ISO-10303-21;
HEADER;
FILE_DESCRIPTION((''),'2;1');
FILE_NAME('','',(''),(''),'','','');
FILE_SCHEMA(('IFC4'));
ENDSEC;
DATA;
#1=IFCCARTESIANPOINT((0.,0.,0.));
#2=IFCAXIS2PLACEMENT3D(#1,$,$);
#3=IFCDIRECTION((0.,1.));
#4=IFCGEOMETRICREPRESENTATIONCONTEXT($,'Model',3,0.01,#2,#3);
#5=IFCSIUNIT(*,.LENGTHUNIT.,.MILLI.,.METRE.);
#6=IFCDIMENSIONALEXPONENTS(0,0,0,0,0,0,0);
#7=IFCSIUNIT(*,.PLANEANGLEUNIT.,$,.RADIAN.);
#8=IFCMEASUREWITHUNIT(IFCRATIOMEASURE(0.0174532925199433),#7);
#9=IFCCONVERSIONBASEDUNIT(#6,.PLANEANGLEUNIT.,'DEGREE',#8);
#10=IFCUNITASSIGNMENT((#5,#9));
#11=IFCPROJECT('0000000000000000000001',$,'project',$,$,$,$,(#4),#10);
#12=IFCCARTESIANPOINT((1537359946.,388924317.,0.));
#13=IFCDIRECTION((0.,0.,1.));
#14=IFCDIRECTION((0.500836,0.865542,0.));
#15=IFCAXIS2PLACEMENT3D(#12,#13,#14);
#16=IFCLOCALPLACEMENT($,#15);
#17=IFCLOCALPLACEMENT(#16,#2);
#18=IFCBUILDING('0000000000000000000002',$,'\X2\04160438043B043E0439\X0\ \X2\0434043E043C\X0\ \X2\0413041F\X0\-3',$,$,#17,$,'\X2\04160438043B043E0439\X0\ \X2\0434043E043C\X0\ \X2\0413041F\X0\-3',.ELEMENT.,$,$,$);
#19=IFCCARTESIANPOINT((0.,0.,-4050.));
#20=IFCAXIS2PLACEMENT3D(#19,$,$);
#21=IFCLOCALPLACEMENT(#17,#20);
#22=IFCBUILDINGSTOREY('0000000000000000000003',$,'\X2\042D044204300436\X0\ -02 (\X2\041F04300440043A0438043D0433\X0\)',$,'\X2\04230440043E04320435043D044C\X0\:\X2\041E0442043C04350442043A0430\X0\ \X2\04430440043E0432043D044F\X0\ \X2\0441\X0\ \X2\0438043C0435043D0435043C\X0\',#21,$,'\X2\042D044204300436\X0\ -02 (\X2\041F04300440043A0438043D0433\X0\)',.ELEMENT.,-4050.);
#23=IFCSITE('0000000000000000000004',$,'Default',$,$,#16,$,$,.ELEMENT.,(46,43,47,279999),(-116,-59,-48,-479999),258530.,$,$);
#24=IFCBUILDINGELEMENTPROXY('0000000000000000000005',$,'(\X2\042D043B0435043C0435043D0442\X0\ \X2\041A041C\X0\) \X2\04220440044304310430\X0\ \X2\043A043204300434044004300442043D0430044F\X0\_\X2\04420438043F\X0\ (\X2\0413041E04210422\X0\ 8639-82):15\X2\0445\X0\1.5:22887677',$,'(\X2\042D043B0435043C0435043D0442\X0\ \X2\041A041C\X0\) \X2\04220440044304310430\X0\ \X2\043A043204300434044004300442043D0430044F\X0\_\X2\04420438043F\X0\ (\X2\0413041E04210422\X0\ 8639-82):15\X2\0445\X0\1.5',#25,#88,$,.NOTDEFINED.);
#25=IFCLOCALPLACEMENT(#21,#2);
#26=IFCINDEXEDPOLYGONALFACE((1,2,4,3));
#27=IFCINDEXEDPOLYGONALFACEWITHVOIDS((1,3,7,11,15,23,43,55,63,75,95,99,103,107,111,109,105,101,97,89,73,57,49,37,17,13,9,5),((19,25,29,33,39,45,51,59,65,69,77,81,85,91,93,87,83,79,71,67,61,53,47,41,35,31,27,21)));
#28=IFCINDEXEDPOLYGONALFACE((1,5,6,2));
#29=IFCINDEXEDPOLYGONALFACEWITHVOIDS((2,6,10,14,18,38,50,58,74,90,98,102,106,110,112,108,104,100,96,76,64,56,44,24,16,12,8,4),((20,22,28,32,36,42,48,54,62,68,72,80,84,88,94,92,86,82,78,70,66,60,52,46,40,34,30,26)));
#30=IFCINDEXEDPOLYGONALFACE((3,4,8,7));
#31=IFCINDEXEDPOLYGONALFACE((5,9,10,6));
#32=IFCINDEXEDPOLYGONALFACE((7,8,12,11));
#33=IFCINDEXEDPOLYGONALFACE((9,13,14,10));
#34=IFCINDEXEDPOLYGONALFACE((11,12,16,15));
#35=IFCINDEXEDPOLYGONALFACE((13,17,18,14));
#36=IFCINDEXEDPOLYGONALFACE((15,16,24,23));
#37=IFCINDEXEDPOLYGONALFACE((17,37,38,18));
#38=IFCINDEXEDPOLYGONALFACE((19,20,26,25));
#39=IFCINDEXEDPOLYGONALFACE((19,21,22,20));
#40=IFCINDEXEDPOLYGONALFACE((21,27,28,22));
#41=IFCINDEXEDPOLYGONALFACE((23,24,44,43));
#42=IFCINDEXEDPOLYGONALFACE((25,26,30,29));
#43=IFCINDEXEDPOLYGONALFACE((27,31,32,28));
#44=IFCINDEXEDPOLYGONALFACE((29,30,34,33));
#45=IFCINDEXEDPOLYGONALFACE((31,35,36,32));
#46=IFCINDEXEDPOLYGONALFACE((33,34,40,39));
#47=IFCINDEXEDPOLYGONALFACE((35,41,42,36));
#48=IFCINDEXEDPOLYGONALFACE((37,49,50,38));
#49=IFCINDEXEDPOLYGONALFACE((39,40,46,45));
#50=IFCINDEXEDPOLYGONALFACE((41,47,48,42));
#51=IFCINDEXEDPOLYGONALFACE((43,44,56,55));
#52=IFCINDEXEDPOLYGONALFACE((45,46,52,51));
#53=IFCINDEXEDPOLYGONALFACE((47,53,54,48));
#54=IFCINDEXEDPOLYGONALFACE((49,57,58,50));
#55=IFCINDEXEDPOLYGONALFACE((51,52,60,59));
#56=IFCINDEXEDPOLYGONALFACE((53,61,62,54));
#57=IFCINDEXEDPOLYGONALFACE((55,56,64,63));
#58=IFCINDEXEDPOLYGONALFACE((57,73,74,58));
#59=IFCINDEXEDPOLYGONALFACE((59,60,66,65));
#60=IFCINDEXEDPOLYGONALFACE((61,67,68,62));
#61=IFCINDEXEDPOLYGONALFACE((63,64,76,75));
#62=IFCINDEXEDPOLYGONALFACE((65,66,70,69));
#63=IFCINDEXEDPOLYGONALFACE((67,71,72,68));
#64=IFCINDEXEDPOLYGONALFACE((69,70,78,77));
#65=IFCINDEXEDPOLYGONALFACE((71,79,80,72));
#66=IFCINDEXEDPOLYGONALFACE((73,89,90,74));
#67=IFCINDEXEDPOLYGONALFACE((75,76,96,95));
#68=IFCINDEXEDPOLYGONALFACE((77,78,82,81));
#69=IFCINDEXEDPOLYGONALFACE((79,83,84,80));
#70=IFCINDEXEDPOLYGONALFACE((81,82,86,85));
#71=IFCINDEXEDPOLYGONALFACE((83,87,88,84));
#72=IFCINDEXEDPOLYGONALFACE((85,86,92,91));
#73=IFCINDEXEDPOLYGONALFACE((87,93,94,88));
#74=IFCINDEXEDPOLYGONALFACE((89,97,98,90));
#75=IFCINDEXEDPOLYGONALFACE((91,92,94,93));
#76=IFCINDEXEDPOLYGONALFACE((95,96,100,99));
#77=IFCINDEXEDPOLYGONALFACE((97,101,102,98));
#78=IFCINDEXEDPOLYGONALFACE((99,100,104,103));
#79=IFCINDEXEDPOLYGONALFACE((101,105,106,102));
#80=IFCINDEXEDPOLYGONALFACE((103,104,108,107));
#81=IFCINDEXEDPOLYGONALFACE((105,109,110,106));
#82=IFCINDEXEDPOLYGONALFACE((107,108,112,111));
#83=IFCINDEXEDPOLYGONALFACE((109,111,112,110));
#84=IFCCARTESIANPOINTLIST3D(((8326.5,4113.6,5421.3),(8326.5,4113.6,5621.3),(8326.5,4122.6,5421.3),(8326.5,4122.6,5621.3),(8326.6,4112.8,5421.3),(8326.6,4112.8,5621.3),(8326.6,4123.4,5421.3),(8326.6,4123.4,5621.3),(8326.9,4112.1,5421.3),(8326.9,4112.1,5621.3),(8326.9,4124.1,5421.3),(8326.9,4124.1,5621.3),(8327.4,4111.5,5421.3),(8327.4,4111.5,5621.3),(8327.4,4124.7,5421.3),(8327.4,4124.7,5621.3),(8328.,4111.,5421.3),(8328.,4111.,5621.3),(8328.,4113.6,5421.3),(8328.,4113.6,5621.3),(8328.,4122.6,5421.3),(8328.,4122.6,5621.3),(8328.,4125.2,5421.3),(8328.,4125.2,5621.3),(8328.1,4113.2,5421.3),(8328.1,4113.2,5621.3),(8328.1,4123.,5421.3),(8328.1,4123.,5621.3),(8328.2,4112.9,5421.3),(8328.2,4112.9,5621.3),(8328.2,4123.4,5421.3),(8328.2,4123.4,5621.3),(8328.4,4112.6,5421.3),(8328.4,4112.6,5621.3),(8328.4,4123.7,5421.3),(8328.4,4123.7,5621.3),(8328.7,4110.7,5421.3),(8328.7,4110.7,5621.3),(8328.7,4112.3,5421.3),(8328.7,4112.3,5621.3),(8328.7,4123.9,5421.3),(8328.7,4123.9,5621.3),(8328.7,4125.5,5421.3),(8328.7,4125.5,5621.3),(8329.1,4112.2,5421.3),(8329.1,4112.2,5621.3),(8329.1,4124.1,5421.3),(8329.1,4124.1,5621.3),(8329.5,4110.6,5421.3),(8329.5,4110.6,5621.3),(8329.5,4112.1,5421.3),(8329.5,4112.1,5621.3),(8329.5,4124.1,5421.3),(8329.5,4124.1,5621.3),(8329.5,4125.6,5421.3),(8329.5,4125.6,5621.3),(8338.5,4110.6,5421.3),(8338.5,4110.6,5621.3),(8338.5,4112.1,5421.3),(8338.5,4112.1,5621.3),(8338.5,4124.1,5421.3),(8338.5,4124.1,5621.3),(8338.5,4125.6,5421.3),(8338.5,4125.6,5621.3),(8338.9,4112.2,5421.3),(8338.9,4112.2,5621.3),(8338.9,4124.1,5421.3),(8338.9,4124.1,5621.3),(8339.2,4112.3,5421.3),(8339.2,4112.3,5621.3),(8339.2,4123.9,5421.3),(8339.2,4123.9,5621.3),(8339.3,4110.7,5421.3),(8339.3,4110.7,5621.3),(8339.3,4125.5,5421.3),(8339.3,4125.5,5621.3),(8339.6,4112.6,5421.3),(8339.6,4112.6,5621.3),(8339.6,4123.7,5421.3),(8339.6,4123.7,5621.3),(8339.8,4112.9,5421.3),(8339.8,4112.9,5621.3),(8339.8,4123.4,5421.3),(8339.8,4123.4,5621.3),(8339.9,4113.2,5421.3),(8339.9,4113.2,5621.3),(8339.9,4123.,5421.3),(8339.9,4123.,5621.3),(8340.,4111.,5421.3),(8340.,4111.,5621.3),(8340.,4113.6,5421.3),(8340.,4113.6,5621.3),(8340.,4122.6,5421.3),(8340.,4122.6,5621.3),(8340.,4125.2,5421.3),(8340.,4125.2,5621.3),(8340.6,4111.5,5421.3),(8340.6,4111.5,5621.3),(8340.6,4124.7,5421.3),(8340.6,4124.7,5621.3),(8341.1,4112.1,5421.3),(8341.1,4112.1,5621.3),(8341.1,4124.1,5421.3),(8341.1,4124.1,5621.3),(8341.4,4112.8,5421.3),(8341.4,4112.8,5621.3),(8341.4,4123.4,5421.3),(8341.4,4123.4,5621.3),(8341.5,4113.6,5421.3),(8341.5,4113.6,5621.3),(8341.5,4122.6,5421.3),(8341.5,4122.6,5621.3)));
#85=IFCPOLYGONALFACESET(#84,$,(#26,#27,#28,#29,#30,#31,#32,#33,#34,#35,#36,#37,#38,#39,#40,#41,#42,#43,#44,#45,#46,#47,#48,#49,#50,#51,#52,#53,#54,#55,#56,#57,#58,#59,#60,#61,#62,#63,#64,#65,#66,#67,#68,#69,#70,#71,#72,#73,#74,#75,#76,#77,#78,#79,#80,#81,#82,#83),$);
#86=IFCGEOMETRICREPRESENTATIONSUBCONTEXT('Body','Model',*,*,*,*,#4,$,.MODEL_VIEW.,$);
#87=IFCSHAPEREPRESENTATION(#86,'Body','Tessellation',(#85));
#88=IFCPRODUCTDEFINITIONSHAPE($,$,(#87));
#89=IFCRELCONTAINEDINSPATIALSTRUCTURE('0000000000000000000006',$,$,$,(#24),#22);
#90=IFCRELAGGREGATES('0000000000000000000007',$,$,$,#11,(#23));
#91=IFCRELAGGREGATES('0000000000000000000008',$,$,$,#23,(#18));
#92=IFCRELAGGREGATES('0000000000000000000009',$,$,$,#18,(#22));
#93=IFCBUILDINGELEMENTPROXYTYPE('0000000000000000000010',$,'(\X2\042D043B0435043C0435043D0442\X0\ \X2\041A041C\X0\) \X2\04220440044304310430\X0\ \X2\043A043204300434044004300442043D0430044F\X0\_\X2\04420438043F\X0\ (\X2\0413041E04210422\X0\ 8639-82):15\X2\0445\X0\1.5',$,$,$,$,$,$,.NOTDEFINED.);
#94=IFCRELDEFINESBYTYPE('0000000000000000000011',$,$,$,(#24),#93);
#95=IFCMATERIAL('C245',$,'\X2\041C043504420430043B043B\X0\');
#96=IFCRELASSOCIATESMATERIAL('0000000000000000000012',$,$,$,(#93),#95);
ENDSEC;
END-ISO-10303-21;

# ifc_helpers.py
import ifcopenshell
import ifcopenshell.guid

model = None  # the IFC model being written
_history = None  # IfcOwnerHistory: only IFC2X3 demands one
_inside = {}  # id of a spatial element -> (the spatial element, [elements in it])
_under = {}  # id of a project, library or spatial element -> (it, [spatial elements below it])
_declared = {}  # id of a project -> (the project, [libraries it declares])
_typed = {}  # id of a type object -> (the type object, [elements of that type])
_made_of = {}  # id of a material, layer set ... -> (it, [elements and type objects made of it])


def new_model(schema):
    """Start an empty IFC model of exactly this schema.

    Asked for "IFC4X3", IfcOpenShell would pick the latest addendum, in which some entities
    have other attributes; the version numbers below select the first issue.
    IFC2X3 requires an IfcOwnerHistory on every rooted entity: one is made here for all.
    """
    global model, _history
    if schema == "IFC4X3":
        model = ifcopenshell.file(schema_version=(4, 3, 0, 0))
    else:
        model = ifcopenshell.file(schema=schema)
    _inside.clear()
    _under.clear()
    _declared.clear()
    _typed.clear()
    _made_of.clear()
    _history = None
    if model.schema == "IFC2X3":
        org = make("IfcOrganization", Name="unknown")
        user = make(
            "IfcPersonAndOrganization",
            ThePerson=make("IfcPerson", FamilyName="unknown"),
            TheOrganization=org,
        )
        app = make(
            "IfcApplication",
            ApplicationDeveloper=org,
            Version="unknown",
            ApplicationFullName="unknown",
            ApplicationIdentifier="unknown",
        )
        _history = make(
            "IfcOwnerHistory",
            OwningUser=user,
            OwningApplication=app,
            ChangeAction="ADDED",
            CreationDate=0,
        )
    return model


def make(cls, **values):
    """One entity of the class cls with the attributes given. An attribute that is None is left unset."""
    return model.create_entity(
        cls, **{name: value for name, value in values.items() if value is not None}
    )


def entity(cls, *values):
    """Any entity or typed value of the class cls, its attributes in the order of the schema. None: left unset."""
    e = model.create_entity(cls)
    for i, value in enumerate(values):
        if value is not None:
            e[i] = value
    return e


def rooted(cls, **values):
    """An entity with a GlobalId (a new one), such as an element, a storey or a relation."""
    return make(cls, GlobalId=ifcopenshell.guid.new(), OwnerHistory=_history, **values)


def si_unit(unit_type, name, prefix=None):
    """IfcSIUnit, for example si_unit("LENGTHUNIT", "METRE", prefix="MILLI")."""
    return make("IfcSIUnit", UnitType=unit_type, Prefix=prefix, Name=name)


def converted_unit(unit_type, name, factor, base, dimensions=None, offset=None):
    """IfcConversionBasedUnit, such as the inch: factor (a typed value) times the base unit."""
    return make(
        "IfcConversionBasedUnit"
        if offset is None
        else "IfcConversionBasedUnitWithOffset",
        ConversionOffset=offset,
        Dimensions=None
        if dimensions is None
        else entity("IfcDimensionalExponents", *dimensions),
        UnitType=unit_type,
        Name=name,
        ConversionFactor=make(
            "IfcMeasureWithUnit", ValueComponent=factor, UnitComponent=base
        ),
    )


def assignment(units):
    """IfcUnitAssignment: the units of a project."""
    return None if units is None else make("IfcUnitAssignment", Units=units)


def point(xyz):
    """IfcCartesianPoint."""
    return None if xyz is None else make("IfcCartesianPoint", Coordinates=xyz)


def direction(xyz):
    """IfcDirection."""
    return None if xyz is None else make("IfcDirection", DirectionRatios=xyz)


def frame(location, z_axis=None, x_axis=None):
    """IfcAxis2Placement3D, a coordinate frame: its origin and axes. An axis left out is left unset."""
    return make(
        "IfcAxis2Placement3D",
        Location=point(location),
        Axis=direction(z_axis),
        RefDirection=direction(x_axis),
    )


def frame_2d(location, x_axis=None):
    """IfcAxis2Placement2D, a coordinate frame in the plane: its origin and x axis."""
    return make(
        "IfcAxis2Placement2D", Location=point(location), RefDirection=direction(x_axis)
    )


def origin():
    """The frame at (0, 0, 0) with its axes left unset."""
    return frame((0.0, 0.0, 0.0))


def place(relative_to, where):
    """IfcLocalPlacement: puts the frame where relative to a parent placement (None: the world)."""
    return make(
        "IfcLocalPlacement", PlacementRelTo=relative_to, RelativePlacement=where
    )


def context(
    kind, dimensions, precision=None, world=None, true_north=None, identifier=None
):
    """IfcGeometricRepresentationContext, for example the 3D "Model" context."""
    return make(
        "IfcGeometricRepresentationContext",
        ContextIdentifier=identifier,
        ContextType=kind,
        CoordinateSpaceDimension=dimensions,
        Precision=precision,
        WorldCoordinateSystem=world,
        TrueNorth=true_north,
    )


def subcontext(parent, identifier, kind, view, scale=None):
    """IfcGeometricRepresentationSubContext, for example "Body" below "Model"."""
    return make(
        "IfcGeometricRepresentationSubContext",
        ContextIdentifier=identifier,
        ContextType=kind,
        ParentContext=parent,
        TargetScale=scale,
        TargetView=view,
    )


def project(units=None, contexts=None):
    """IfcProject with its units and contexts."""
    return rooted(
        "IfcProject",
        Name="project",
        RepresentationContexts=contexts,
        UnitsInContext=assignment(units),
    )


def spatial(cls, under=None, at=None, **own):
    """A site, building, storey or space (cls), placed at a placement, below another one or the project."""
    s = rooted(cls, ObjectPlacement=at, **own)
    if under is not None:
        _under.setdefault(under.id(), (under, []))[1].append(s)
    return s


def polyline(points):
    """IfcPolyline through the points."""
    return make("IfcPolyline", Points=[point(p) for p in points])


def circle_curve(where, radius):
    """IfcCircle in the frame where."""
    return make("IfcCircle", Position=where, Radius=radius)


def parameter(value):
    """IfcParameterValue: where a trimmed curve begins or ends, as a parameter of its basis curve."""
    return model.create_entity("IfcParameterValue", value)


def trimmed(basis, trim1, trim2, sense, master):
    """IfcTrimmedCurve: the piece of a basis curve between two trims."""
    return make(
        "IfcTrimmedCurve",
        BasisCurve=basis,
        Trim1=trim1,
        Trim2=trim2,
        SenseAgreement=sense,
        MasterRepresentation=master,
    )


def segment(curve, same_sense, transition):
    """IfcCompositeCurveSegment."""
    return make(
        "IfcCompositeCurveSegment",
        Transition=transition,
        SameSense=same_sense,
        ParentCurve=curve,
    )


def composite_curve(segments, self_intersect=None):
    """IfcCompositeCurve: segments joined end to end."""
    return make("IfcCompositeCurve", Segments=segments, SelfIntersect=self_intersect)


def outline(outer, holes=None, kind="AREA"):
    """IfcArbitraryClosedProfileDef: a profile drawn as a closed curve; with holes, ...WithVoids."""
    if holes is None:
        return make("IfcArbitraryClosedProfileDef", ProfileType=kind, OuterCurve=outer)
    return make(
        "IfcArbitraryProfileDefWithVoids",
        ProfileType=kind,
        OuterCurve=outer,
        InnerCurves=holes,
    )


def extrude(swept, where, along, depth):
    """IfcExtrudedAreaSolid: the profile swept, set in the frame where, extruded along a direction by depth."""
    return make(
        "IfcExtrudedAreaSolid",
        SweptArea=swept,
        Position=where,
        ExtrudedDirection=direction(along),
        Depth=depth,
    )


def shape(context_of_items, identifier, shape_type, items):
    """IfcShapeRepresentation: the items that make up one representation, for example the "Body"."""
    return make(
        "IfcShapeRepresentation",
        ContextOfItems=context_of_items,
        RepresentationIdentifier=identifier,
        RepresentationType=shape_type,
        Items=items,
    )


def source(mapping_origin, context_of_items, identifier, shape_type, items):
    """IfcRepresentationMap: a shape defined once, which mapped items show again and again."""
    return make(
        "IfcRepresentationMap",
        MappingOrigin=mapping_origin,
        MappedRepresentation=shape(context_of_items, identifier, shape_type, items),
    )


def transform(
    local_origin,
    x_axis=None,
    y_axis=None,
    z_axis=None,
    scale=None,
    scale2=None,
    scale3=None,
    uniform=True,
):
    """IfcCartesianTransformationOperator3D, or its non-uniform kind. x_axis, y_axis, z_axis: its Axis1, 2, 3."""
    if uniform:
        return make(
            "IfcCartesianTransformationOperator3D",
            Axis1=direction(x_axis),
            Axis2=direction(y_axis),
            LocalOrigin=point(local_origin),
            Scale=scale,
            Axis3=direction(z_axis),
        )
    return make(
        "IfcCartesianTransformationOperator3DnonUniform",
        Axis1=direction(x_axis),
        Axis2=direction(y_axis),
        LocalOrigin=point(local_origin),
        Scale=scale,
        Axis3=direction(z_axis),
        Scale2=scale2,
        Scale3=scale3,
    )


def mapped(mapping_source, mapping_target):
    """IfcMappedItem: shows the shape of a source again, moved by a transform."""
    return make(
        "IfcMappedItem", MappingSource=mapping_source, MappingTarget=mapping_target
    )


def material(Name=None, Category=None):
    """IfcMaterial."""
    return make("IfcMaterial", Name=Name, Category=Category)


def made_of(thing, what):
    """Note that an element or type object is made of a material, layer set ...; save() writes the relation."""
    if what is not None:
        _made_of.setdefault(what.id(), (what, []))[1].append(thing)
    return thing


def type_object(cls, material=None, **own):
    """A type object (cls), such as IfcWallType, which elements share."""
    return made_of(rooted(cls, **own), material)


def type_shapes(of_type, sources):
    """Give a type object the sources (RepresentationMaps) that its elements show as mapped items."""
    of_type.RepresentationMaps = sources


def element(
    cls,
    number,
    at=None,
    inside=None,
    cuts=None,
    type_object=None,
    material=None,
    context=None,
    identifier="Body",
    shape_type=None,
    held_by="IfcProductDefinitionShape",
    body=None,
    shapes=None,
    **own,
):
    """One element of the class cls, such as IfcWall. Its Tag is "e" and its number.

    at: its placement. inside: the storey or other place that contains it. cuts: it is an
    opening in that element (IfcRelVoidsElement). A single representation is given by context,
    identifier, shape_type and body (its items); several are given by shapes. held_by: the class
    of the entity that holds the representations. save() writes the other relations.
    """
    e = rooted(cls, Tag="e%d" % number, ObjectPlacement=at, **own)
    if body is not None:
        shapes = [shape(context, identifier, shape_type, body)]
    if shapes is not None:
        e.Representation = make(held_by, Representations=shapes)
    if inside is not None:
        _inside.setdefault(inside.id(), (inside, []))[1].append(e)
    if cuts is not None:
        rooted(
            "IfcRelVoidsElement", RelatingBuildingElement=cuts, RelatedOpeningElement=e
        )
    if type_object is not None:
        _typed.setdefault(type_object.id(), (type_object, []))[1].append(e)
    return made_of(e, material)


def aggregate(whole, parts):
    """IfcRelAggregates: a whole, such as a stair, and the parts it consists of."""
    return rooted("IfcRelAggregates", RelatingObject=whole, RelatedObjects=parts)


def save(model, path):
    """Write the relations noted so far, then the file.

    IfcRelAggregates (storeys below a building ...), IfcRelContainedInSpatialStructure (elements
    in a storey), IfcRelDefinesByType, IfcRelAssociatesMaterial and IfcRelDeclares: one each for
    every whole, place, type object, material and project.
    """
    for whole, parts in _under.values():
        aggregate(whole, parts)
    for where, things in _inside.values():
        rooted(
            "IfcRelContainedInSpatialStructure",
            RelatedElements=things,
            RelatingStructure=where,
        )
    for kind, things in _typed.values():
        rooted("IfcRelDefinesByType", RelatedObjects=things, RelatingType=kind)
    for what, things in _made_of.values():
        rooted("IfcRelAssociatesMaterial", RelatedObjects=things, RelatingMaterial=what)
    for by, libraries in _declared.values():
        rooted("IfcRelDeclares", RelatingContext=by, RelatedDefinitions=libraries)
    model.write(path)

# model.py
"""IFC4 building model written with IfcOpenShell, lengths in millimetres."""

from ifc_helpers import new_model, entity, si_unit, converted_unit, direction, frame, frame_2d, origin, place, context, subcontext, project, spatial, polyline, circle_curve, parameter, trimmed, segment, composite_curve, outline, extrude, source, transform, mapped, material, type_object, type_shapes, element, save


model = new_model("IFC4")

# Units and contexts
model_context = context("Model", 3, precision=0.01, world=origin(), true_north=direction((0.0, 1.0)))
body_context = subcontext(model_context, "Body", "Model", "MODEL_VIEW")
ifc_project = project(units=[si_unit("LENGTHUNIT", "METRE", prefix="MILLI"), converted_unit("PLANEANGLEUNIT", "DEGREE", entity("IfcRatioMeasure", 0.0174532925199433), si_unit("PLANEANGLEUNIT", "RADIAN"), dimensions=[0, 0, 0, 0, 0, 0, 0])], contexts=[model_context])

# Site, building, storey
site_placement = place(None, frame((1537359946.0, 388924317.0, 0.0), z_axis=(0.0, 0.0, 1.0), x_axis=(0.500836, 0.865542, 0.0)))
site = spatial("IfcSite", under=ifc_project, at=site_placement, Name="Default", CompositionType="ELEMENT", RefLatitude=(46, 43, 47, 279999), RefLongitude=(-116, -59, -48, -479999), RefElevation=258530.0)
building_placement = place(site_placement, origin())
building = spatial("IfcBuilding", under=site, at=building_placement, Name="Жилой дом ГП-3", LongName="Жилой дом ГП-3", CompositionType="ELEMENT")
storey_placement = place(building_placement, frame((0.0, 0.0, -4050.0)))
storey = spatial("IfcBuildingStorey", under=building, at=storey_placement, Name="Этаж -02 (Паркинг)", ObjectType="Уровень:Отметка уровня с именем", LongName="Этаж -02 (Паркинг)", CompositionType="ELEMENT", Elevation=-4050.0)

# Building element proxy
ifc_material_1 = material(Name="C245", Category="Металл")
building_element_proxy_type_1 = type_object("IfcBuildingElementProxyType", Name="(Элемент КМ) Труба квадратная_тип (ГОСТ 8639-82):15х1.5", PredefinedType="NOTDEFINED", material=ifc_material_1)
shared_shape_1 = source(origin(), body_context, "Body", "SweptSolid", [
    extrude(outline(composite_curve([segment(trimmed(circle_curve(frame_2d((4.5, -4.5), x_axis=(1.0, 0.0)), 3.0), [parameter(270.0)], [parameter(0.0)], True, "PARAMETER"), True, "CONTINUOUS"), segment(polyline([(7.5, -4.5), (7.5, 4.5)]), True, "CONTINUOUS"), segment(trimmed(circle_curve(frame_2d((4.5, 4.5), x_axis=(1.0, 0.0)), 3.0), [parameter(0.0)], [parameter(90.0)], True, "PARAMETER"), True, "CONTINUOUS"), segment(polyline([(4.5, 7.5), (-4.5, 7.5)]), True, "CONTINUOUS"), segment(trimmed(circle_curve(frame_2d((-4.5, 4.5), x_axis=(1.0, 0.0)), 3.0), [parameter(90.0)], [parameter(180.0)], True, "PARAMETER"), True, "CONTINUOUS"), segment(polyline([(-7.5, 4.5), (-7.5, -4.5)]), True, "CONTINUOUS"), segment(trimmed(circle_curve(frame_2d((-4.5, -4.5), x_axis=(1.0, 0.0)), 3.0), [parameter(180.0)], [parameter(270.0)], True, "PARAMETER"), True, "CONTINUOUS"), segment(polyline([(-4.5, -7.5), (4.5, -7.5)]), True, "CONTINUOUS")], self_intersect=False), holes=[composite_curve([segment(polyline([(4.5, -6.0), (-4.5, -6.0)]), True, "CONTINUOUS"), segment(trimmed(circle_curve(frame_2d((-4.5, -4.5), x_axis=(1.0, 0.0)), 1.5), [parameter(180.0)], [parameter(270.0)], True, "PARAMETER"), False, "CONTINUOUS"), segment(polyline([(-6.0, -4.5), (-6.0, 4.5)]), True, "CONTINUOUS"), segment(trimmed(circle_curve(frame_2d((-4.5, 4.5), x_axis=(1.0, 0.0)), 1.5), [parameter(90.0)], [parameter(180.0)], True, "PARAMETER"), False, "CONTINUOUS"), segment(polyline([(-4.5, 6.0), (4.5, 6.0)]), True, "CONTINUOUS"), segment(trimmed(circle_curve(frame_2d((4.5, 4.5), x_axis=(1.0, 0.0)), 1.5), [parameter(0.0)], [parameter(90.0)], True, "PARAMETER"), False, "CONTINUOUS"), segment(polyline([(6.0, 4.5), (6.0, -4.5)]), True, "CONTINUOUS"), segment(trimmed(circle_curve(frame_2d((4.5, -4.5), x_axis=(1.0, 0.0)), 1.5), [parameter(270.0)], [parameter(0.0)], True, "PARAMETER"), False, "CONTINUOUS")], self_intersect=False)]), frame((-100.0, 0.0, 0.0), z_axis=(1.0, 0.0, 0.0), x_axis=(0.0, -1.0, 0.0)), (0.0, 0.0, 1.0), 200.0),
])
type_shapes(building_element_proxy_type_1, [shared_shape_1])
for number, where, z_axis, x_axis, name in (
    (1, (8334.0, 4118.1, 5521.3), (1.0, 0.0, 0.0), (0.0, 0.0, 1.0), "(Элемент КМ) Труба квадратная_тип (ГОСТ 8639-82):15х1.5:22887677"),
):
    element("IfcBuildingElementProxy", number, at=place(storey_placement, frame(where, z_axis=z_axis, x_axis=x_axis)), inside=storey, type_object=building_element_proxy_type_1, Name=name, ObjectType="(Элемент КМ) Труба квадратная_тип (ГОСТ 8639-82):15х1.5", PredefinedType="NOTDEFINED", context=body_context, shape_type="MappedRepresentation", body=[
        mapped(shared_shape_1, transform((0.0, 0.0, 0.0), scale=1.0)),
    ])

save(model, "model.ifc")
